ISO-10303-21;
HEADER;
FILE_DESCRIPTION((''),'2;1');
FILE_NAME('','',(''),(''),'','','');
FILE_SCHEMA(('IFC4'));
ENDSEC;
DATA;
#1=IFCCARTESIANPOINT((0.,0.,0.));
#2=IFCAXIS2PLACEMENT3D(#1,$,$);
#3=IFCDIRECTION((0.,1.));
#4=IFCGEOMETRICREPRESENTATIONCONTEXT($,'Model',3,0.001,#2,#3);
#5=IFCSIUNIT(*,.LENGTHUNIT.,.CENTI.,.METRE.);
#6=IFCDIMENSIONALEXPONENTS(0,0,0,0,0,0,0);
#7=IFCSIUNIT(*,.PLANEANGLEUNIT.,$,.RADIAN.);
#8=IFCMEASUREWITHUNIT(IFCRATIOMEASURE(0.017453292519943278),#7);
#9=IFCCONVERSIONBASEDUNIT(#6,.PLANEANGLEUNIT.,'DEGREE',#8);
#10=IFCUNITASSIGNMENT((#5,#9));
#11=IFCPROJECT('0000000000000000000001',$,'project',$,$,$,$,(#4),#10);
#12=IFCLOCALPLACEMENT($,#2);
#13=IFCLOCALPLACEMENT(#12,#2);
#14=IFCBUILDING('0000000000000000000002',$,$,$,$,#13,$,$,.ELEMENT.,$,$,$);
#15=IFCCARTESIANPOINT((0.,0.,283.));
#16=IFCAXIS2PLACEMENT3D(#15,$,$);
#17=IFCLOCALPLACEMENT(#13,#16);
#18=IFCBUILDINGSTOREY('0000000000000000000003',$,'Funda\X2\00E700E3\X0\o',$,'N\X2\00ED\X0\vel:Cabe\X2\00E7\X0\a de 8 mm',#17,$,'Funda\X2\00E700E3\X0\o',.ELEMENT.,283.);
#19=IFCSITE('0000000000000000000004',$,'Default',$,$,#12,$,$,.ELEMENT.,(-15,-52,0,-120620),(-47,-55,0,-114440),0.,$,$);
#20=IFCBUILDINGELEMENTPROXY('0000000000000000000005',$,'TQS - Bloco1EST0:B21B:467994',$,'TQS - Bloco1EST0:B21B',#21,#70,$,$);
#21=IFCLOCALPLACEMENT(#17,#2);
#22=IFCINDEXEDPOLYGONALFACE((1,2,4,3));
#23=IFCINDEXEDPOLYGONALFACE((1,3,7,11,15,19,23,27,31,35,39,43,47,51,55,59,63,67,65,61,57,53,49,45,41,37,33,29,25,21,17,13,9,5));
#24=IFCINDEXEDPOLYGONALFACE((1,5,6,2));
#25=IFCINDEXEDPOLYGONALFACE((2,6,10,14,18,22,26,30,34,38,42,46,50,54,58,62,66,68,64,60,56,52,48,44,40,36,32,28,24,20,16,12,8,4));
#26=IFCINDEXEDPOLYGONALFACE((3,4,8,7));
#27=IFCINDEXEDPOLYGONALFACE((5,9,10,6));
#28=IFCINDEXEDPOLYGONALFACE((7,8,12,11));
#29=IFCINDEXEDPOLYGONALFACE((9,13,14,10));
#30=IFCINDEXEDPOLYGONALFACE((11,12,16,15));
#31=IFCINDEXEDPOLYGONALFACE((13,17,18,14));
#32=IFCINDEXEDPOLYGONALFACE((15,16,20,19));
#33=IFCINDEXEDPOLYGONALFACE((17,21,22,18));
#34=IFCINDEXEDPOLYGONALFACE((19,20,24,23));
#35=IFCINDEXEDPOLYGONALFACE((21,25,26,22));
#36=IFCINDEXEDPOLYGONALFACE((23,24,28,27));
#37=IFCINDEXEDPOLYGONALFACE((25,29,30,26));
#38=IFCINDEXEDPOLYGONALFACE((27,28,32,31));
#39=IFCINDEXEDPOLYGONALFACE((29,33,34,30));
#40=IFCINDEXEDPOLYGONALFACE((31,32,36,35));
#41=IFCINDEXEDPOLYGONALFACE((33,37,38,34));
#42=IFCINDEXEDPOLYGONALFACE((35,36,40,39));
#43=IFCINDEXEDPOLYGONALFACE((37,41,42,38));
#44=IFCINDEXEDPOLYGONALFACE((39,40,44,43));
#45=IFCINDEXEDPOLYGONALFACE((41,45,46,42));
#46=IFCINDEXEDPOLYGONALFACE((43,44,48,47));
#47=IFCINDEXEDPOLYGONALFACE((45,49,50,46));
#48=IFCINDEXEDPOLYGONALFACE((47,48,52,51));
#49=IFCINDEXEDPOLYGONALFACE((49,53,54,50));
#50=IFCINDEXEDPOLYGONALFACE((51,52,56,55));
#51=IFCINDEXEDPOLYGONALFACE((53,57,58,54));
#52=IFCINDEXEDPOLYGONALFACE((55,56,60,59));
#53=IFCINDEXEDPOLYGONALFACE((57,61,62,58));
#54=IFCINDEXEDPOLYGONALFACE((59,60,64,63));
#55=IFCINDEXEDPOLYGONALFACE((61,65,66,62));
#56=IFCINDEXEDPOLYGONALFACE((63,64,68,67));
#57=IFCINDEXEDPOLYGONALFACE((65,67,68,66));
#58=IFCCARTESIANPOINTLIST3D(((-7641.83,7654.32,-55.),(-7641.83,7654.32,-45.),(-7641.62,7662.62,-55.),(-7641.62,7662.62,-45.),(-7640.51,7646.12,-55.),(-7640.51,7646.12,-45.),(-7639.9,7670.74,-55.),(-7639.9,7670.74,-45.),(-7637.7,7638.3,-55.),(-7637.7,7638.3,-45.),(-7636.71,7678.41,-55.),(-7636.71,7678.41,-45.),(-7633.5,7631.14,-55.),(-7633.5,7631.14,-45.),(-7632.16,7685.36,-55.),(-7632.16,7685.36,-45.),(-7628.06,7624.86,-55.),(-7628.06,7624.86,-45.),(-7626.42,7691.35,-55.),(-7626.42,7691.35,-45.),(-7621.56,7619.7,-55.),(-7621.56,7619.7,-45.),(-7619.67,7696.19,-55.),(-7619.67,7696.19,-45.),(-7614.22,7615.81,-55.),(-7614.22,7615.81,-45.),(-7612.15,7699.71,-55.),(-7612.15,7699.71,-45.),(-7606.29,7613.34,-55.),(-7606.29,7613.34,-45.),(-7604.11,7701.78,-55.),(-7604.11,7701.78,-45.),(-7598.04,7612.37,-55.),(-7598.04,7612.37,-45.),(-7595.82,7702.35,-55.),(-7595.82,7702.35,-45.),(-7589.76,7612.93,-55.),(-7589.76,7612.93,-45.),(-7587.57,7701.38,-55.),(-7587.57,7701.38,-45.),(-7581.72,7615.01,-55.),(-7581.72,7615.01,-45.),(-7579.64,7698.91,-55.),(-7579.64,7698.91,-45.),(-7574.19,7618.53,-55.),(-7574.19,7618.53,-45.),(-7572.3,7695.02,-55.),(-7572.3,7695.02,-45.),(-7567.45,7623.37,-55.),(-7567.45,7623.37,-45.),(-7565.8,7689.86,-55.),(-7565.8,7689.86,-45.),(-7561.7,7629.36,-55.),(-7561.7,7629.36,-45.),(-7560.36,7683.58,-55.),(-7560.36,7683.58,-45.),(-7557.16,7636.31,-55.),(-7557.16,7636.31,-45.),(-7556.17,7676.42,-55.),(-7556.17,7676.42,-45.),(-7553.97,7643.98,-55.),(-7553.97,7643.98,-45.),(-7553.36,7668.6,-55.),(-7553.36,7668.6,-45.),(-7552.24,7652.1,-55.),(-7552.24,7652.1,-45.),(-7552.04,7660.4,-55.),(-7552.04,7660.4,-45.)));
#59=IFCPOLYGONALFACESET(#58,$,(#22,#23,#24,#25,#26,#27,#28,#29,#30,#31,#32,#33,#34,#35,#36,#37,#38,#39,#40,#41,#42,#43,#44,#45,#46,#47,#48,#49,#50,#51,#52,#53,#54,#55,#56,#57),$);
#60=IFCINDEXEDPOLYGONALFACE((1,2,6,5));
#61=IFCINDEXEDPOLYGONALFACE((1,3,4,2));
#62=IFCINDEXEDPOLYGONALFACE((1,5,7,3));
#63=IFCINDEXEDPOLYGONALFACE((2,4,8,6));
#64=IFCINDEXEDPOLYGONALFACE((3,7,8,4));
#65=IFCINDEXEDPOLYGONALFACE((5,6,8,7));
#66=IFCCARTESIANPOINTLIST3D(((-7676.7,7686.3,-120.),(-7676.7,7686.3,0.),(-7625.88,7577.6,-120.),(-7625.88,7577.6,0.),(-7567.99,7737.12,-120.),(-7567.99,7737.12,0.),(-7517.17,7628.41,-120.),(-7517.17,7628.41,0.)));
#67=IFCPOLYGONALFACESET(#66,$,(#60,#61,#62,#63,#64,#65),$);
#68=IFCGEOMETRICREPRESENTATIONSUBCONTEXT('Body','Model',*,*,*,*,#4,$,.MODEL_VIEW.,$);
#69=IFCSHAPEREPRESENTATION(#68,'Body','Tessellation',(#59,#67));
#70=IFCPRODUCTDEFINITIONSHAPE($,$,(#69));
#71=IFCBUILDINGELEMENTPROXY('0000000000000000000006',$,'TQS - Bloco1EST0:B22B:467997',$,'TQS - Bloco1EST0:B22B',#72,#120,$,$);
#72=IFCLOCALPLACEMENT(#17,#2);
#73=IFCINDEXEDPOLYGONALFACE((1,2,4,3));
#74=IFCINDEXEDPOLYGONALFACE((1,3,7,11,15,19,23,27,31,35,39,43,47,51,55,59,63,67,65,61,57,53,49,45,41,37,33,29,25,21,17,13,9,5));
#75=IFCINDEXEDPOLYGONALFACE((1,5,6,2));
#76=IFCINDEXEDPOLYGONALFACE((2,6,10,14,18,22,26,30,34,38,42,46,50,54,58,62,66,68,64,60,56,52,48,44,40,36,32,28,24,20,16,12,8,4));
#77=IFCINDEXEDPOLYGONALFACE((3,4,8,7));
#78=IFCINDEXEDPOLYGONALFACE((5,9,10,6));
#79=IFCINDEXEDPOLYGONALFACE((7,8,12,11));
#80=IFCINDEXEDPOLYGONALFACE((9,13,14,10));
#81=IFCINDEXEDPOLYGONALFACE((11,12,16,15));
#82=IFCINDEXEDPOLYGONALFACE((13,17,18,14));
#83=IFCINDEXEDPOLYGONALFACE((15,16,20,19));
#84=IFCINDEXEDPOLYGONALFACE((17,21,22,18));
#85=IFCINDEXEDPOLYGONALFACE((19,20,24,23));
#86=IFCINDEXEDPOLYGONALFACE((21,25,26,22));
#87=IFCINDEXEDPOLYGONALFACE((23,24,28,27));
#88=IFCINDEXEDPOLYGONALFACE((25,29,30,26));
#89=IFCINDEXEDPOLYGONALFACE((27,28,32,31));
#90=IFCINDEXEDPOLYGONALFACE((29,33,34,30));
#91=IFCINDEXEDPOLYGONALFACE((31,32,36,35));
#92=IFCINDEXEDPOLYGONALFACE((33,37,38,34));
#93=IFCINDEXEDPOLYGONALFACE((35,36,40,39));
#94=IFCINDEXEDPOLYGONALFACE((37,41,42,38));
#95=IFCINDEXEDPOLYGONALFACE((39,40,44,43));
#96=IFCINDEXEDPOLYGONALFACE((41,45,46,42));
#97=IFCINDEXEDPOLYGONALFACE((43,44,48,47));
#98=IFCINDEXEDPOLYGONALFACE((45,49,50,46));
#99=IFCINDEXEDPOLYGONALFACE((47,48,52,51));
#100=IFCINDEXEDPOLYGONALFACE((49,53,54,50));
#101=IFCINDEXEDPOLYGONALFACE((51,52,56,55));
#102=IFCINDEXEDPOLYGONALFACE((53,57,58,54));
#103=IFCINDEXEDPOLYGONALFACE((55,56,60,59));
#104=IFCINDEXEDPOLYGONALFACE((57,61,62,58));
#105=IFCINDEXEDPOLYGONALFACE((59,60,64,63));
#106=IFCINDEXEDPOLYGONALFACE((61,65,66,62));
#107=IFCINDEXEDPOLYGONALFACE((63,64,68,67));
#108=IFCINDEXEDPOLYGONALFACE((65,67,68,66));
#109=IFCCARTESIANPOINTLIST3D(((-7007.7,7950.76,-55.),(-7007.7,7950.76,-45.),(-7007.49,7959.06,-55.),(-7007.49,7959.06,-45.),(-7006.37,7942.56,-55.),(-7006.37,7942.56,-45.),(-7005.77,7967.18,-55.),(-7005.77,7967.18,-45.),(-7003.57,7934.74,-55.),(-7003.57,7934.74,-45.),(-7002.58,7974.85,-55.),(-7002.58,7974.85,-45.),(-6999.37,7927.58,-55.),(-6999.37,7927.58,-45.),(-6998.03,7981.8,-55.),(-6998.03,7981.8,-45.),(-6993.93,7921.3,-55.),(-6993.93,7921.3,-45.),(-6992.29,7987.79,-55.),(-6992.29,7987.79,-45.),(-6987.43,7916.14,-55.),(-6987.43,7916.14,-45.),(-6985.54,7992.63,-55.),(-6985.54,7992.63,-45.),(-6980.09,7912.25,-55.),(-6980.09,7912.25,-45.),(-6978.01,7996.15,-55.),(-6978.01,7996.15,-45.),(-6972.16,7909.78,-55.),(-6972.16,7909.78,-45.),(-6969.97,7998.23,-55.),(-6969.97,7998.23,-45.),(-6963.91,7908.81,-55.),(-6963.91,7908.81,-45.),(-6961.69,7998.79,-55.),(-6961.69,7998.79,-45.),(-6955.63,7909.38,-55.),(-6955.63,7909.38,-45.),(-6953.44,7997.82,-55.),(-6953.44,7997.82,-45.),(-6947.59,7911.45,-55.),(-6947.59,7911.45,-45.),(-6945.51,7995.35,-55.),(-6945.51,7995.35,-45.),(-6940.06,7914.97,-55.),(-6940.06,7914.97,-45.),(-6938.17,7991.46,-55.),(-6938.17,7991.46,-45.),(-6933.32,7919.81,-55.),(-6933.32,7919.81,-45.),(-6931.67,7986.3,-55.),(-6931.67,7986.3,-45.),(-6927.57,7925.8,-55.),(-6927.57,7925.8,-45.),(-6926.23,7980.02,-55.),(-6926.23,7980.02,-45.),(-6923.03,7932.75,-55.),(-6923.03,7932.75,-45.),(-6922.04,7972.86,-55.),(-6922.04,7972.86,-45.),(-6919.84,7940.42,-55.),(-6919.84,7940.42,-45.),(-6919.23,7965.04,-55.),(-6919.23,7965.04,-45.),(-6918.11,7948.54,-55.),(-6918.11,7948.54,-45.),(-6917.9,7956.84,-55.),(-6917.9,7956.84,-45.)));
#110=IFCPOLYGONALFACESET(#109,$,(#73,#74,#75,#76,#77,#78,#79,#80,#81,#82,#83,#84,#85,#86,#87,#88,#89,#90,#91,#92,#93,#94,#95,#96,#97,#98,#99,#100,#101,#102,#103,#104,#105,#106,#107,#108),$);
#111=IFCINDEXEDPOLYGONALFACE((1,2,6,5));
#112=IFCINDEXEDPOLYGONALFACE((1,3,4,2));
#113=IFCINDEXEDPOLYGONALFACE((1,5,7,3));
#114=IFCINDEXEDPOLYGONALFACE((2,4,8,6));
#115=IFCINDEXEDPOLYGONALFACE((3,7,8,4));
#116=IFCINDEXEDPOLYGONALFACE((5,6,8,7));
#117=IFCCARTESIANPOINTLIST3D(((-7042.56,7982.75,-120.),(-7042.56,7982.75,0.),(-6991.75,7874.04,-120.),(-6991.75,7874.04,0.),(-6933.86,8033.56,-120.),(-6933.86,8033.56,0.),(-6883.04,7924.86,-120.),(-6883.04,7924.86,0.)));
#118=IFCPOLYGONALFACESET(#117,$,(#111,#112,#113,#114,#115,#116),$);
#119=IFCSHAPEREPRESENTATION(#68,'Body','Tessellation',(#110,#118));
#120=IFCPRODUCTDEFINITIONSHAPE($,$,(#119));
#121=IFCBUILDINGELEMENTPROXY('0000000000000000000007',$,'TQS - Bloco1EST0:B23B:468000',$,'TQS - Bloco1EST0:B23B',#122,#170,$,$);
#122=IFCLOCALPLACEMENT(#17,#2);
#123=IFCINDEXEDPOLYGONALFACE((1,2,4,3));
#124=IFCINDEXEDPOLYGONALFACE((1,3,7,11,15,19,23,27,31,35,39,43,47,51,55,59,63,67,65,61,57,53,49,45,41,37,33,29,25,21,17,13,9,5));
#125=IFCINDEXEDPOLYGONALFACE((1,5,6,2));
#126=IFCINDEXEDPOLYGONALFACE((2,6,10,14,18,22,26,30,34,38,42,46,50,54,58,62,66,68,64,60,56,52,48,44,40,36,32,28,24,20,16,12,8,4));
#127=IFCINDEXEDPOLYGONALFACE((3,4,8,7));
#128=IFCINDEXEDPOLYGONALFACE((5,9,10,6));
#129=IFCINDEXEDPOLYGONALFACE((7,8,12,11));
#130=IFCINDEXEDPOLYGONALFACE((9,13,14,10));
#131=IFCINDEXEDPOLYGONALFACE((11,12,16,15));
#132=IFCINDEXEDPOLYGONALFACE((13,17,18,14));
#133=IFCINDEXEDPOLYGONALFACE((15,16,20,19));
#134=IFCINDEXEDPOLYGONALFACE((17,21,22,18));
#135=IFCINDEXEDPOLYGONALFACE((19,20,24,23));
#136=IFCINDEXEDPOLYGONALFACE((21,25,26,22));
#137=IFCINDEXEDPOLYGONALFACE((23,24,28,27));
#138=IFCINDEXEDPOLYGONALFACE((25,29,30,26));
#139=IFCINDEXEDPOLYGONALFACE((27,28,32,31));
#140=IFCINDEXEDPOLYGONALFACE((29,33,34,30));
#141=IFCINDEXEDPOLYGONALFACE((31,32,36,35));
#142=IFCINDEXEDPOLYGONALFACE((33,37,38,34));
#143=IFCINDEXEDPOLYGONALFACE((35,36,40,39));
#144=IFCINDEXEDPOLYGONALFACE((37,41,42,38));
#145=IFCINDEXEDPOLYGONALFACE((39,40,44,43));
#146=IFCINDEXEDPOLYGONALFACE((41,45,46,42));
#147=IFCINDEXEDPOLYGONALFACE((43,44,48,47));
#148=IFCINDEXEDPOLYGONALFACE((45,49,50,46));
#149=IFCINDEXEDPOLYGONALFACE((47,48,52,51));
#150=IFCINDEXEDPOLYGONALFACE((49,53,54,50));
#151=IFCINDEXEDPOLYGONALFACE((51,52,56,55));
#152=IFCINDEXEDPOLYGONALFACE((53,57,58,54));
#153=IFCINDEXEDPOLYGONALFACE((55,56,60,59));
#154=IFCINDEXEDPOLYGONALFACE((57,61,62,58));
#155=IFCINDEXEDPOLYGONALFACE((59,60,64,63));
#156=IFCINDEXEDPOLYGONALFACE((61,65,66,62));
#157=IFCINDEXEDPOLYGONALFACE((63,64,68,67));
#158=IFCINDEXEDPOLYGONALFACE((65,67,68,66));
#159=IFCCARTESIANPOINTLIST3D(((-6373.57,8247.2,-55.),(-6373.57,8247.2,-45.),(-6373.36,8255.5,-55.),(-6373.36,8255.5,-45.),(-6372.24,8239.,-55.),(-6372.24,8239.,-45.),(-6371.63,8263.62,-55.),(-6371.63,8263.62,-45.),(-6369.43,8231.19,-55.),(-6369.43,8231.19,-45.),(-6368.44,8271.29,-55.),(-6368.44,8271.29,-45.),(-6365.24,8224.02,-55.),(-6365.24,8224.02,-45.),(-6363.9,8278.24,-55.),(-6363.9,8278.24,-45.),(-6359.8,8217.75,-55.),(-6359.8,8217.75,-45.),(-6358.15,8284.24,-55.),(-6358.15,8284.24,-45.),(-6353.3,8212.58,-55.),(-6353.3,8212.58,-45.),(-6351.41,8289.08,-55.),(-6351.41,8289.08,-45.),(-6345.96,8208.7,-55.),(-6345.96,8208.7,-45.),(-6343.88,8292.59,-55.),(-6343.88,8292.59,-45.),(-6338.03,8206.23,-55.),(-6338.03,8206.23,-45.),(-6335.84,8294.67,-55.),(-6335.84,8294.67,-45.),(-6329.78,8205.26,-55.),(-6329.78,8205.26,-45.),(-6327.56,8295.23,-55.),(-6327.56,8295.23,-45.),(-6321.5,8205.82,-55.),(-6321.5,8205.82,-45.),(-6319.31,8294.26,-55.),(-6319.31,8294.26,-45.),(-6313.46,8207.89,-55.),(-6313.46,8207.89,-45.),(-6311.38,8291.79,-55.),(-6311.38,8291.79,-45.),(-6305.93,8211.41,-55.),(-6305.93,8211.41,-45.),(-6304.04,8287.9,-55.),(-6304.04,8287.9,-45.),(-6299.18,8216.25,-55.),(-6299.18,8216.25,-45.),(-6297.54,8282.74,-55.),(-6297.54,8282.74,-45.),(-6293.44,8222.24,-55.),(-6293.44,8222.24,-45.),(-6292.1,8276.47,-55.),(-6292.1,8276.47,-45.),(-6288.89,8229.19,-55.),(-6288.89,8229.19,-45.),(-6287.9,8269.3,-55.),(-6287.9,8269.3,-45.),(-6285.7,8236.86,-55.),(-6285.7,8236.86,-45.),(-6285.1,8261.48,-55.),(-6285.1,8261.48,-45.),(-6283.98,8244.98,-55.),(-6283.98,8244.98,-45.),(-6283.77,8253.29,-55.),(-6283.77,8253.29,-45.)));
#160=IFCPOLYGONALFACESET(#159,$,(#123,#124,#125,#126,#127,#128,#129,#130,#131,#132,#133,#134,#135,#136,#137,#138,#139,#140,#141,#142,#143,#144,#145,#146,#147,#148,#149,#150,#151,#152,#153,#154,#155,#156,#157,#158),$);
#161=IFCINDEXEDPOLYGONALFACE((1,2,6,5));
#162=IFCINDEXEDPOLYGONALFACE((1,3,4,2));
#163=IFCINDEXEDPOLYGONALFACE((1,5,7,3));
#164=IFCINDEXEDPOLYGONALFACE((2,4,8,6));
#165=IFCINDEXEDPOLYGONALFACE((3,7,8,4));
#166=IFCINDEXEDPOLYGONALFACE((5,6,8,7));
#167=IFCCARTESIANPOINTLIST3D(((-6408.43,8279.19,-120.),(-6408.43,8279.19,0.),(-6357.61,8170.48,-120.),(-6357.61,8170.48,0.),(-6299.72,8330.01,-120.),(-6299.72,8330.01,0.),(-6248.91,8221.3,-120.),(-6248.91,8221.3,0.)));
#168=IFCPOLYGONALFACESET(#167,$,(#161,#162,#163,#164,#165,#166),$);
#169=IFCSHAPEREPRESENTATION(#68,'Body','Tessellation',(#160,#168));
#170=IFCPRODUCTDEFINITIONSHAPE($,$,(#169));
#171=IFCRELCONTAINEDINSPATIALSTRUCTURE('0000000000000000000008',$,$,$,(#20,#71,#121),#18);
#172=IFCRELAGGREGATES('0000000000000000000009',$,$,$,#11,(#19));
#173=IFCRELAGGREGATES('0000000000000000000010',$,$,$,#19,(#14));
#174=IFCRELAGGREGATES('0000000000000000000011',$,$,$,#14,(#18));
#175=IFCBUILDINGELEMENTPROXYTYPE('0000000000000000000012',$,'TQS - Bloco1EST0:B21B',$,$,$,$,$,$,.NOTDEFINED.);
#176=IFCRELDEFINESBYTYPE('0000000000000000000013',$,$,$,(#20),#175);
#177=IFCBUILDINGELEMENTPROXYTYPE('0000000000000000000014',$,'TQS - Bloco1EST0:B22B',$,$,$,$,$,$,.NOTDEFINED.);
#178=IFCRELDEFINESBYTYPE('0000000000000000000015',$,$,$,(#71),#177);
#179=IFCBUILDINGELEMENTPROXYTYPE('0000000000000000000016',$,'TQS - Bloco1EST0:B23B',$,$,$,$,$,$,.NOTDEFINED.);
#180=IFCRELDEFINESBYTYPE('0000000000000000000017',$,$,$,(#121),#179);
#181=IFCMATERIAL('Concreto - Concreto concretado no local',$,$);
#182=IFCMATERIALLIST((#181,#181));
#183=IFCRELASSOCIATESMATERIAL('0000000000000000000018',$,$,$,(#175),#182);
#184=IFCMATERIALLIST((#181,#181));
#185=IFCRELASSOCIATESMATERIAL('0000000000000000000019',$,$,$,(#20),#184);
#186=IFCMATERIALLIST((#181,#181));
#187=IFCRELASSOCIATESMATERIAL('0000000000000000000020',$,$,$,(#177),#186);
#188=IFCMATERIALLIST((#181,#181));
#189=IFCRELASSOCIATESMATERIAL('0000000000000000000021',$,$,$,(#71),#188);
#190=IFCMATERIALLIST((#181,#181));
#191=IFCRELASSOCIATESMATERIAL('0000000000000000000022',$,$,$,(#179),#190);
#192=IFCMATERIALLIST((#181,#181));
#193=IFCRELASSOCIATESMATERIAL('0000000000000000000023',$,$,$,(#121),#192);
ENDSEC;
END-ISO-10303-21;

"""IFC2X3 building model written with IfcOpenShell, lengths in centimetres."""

from ifc_helpers import new_model, entity, si_unit, converted_unit, direction, frame, frame_2d, origin, origin_2d_with_axis, place, context, subcontext, project, spatial, rectangle, circle, extrude, source, transform, mapped, material, material_list, type_object, type_shapes, element, save


model = new_model("IFC2X3")

# Units and contexts
model_context = context("Model", 3, precision=0.001, world=origin(), true_north=direction((0.0, 1.0)))
body_context = subcontext(model_context, "Body", "Model", "MODEL_VIEW")
ifc_project = project(units=[si_unit("LENGTHUNIT", "METRE", prefix="CENTI"), converted_unit("PLANEANGLEUNIT", "DEGREE", entity("IfcRatioMeasure", 0.017453292519943278), si_unit("PLANEANGLEUNIT", "RADIAN"), dimensions=[0, 0, 0, 0, 0, 0, 0])], contexts=[model_context])

# Site, building, storey
site_placement = place(None, origin())
site = spatial("IfcSite", under=ifc_project, at=site_placement, Name="Default", CompositionType="ELEMENT", RefLatitude=(-15, -52, 0, -120620), RefLongitude=(-47, -55, 0, -114440), RefElevation=0.0)
building_placement = place(site_placement, origin())
building = spatial("IfcBuilding", under=site, at=building_placement, CompositionType="ELEMENT")
storey_placement = place(building_placement, frame((0.0, 0.0, 283.0)))
storey = spatial("IfcBuildingStorey", under=building, at=storey_placement, Name="Fundação", ObjectType="Nível:Cabeça de 8 mm", LongName="Fundação", CompositionType="ELEMENT", Elevation=283.0)

# Building element proxies
ifc_material_1 = material(Name="Concreto - Concreto concretado no local")
ifc_material_list_1 = material_list([ifc_material_1, ifc_material_1])
ifc_material_list_2 = material_list([ifc_material_1, ifc_material_1])
building_element_proxy_type_1 = type_object("IfcBuildingElementProxyType", Name="TQS - Bloco1EST0:B21B", PredefinedType="NOTDEFINED", material=ifc_material_list_2)
shared_shape_1 = source(origin(), body_context, "Body", "SweptSolid", [
    extrude(circle(Radius=45.0, at=frame_2d((0.0, 0.0), x_axis=(1.0, 0.0))), frame((0.0, 0.0, -55.0)), (0.0, 0.0, 1.0), 10.0),
    extrude(rectangle(XDim=120.0, YDim=120.0, at=origin_2d_with_axis()), frame((0.0, 0.0, -120.0), z_axis=(0.0, 0.0, 1.0), x_axis=(-1.0, 0.0, 0.0)), (0.0, 0.0, 1.0), 120.0),
])
type_shapes(building_element_proxy_type_1, [shared_shape_1])
proxy_1_placement = place(storey_placement, frame((-7596.93, 7657.36, 0.0), z_axis=(0.0, 0.0, 1.0), x_axis=(0.905902, 0.423488, 0.0)))
element("IfcBuildingElementProxy", 1, at=proxy_1_placement, inside=storey, type_object=building_element_proxy_type_1, material=ifc_material_list_1, Name="TQS - Bloco1EST0:B21B:467994", ObjectType="TQS - Bloco1EST0:B21B", context=body_context, shape_type="MappedRepresentation", body=[
    mapped(shared_shape_1, transform((0.0, 0.0, 0.0), scale=1.0)),
])
ifc_material_list_3 = material_list([ifc_material_1, ifc_material_1])
ifc_material_list_4 = material_list([ifc_material_1, ifc_material_1])
building_element_proxy_type_2 = type_object("IfcBuildingElementProxyType", Name="TQS - Bloco1EST0:B22B", PredefinedType="NOTDEFINED", material=ifc_material_list_4)
shared_shape_2 = source(origin(), body_context, "Body", "SweptSolid", [
    extrude(circle(Radius=45.0, at=frame_2d((0.0, 0.0), x_axis=(1.0, 0.0))), frame((0.0, 0.0, -55.0)), (0.0, 0.0, 1.0), 10.0),
    extrude(rectangle(XDim=120.0, YDim=120.0, at=origin_2d_with_axis()), frame((0.0, 0.0, -120.0), z_axis=(0.0, 0.0, 1.0), x_axis=(-1.0, 0.0, 0.0)), (0.0, 0.0, 1.0), 120.0),
])
type_shapes(building_element_proxy_type_2, [shared_shape_2])
proxy_2_placement = place(storey_placement, frame((-6962.8, 7953.8, 0.0), z_axis=(0.0, 0.0, 1.0), x_axis=(0.905902, 0.423488, 0.0)))
element("IfcBuildingElementProxy", 2, at=proxy_2_placement, inside=storey, type_object=building_element_proxy_type_2, material=ifc_material_list_3, Name="TQS - Bloco1EST0:B22B:467997", ObjectType="TQS - Bloco1EST0:B22B", context=body_context, shape_type="MappedRepresentation", body=[
    mapped(shared_shape_2, transform((0.0, 0.0, 0.0), scale=1.0)),
])
ifc_material_list_5 = material_list([ifc_material_1, ifc_material_1])
ifc_material_list_6 = material_list([ifc_material_1, ifc_material_1])
building_element_proxy_type_3 = type_object("IfcBuildingElementProxyType", Name="TQS - Bloco1EST0:B23B", PredefinedType="NOTDEFINED", material=ifc_material_list_6)
shared_shape_3 = source(origin(), body_context, "Body", "SweptSolid", [
    extrude(circle(Radius=45.0, at=frame_2d((0.0, 0.0), x_axis=(1.0, 0.0))), frame((0.0, 0.0, -55.0)), (0.0, 0.0, 1.0), 10.0),
    extrude(rectangle(XDim=120.0, YDim=120.0, at=origin_2d_with_axis()), frame((0.0, 0.0, -120.0), z_axis=(0.0, 0.0, 1.0), x_axis=(-1.0, 0.0, 0.0)), (0.0, 0.0, 1.0), 120.0),
])
type_shapes(building_element_proxy_type_3, [shared_shape_3])
proxy_3_placement = place(storey_placement, frame((-6328.67, 8250.24, 0.0), z_axis=(0.0, 0.0, 1.0), x_axis=(0.905902, 0.423488, 0.0)))
element("IfcBuildingElementProxy", 3, at=proxy_3_placement, inside=storey, type_object=building_element_proxy_type_3, material=ifc_material_list_5, Name="TQS - Bloco1EST0:B23B:468000", ObjectType="TQS - Bloco1EST0:B23B", context=body_context, shape_type="MappedRepresentation", body=[
    mapped(shared_shape_3, transform((0.0, 0.0, 0.0), scale=1.0)),
])

save(model, "model.ifc")
